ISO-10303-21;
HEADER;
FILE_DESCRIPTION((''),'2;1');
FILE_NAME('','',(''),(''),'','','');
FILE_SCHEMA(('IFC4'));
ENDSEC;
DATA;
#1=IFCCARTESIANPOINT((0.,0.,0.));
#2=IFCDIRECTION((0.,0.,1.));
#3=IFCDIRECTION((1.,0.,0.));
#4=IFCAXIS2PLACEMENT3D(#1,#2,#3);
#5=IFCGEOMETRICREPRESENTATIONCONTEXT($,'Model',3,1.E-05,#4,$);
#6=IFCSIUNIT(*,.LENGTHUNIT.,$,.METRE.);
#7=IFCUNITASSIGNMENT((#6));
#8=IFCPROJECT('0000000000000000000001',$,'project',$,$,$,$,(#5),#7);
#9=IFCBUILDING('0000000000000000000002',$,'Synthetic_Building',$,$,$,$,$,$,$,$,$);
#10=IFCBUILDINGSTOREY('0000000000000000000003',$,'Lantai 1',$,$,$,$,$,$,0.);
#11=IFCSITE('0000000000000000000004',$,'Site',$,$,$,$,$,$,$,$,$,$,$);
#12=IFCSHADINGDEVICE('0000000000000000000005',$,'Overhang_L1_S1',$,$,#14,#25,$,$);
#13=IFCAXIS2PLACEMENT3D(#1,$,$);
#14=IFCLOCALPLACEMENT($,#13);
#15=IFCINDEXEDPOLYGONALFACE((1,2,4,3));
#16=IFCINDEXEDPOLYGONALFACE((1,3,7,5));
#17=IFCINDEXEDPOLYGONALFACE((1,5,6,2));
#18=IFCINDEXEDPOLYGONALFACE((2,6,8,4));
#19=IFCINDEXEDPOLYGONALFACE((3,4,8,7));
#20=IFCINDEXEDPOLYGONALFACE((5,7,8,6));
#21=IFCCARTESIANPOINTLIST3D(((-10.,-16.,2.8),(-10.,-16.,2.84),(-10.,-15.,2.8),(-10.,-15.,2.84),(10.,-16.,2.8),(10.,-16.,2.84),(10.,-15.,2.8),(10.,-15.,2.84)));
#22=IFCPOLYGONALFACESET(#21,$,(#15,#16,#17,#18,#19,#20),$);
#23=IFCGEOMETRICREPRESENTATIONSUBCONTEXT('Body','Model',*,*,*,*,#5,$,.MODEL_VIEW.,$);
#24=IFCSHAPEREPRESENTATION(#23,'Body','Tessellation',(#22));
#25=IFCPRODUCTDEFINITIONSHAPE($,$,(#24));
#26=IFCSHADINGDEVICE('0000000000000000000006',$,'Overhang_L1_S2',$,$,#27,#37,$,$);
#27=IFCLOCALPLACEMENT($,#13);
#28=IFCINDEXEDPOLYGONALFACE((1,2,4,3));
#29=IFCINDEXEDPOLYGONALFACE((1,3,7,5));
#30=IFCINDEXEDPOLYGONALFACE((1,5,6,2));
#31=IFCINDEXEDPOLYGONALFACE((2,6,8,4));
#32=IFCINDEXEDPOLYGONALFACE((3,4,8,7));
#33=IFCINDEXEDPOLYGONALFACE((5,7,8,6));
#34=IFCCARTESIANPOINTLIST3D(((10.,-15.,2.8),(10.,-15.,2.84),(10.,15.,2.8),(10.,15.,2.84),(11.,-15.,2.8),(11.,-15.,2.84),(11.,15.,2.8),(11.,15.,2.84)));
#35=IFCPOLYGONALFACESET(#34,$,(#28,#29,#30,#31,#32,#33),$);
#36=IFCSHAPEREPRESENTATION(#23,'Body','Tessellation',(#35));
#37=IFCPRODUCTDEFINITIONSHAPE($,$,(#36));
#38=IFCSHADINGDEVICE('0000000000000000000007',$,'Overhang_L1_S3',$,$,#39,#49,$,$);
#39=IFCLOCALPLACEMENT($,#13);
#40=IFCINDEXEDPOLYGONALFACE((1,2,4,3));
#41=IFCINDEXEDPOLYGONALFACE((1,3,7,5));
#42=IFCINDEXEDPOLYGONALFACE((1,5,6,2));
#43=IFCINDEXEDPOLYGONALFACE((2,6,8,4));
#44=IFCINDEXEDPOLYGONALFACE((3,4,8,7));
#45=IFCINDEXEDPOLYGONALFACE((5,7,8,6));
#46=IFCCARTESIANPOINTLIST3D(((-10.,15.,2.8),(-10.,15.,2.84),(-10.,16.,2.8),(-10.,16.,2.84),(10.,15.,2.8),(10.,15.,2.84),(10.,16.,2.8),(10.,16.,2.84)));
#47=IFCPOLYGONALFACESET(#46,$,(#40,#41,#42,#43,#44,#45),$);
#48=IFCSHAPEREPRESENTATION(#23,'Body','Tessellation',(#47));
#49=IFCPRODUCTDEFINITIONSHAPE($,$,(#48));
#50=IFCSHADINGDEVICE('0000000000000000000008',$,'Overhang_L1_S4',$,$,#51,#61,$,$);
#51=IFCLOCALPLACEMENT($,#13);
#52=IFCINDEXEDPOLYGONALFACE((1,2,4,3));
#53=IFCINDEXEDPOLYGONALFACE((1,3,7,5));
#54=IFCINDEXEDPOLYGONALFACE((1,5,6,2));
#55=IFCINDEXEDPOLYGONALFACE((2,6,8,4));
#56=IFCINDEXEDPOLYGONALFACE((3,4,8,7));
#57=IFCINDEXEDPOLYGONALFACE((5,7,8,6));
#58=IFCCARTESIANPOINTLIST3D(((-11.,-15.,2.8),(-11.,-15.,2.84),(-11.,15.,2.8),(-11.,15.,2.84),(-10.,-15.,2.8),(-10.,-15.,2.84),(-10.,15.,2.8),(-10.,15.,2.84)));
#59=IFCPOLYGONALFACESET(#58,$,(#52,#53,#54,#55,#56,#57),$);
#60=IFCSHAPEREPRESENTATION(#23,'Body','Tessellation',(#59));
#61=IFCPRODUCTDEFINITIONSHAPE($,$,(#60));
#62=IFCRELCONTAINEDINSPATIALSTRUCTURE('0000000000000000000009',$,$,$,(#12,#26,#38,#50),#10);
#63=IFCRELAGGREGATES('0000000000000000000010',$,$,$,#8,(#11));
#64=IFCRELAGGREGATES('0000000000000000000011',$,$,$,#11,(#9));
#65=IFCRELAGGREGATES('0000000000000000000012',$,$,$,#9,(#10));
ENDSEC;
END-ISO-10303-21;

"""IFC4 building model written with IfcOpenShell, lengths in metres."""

from ifc_helpers import new_model, si_unit, frame, origin_with_axes, place, context, subcontext, project, spatial, polyline, outline, extrude, element, save


model = new_model("IFC4")

# Units and contexts
model_context = context("Model", 3, precision=1e-05, world=origin_with_axes())
body_context = subcontext(model_context, "Body", "Model", "MODEL_VIEW")
ifc_project = project(units=[si_unit("LENGTHUNIT", "METRE")], contexts=[model_context])

# Site, building, storey
site = spatial("IfcSite", under=ifc_project, Name="Site")
building = spatial("IfcBuilding", under=site, Name="Synthetic_Building")
storey = spatial("IfcBuildingStorey", under=building, Name="Lantai 1", Elevation=0.0)

# Shading devices
shading_device_1_placement = place(None, origin_with_axes())
element("IfcShadingDevice", 1, at=shading_device_1_placement, inside=storey, Name="Overhang_L1_S1", context=body_context, shape_type="SweptSolid", body=[
    extrude(outline(polyline([(-10.0, -15.0), (-10.0, -16.0), (10.0, -16.0), (10.0, -15.0), (-10.0, -15.0)])), frame((0.0, 0.0, 2.8), z_axis=(0.0, 0.0, 1.0), x_axis=(1.0, 0.0, 0.0)), (0.0, 0.0, 1.0), 0.04),
])
shading_device_2_placement = place(None, origin_with_axes())
element("IfcShadingDevice", 2, at=shading_device_2_placement, inside=storey, Name="Overhang_L1_S2", context=body_context, shape_type="SweptSolid", body=[
    extrude(outline(polyline([(10.0, -15.0), (11.0, -15.0), (11.0, 15.0), (10.0, 15.0), (10.0, -15.0)])), frame((0.0, 0.0, 2.8), z_axis=(0.0, 0.0, 1.0), x_axis=(1.0, 0.0, 0.0)), (0.0, 0.0, 1.0), 0.04),
])
shading_device_3_placement = place(None, origin_with_axes())
element("IfcShadingDevice", 3, at=shading_device_3_placement, inside=storey, Name="Overhang_L1_S3", context=body_context, shape_type="SweptSolid", body=[
    extrude(outline(polyline([(10.0, 15.0), (10.0, 16.0), (-10.0, 16.0), (-10.0, 15.0), (10.0, 15.0)])), frame((0.0, 0.0, 2.8), z_axis=(0.0, 0.0, 1.0), x_axis=(1.0, 0.0, 0.0)), (0.0, 0.0, 1.0), 0.04),
])
shading_device_4_placement = place(None, origin_with_axes())
element("IfcShadingDevice", 4, at=shading_device_4_placement, inside=storey, Name="Overhang_L1_S4", context=body_context, shape_type="SweptSolid", body=[
    extrude(outline(polyline([(-10.0, 15.0), (-11.0, 15.0), (-11.0, -15.0), (-10.0, -15.0), (-10.0, 15.0)])), frame((0.0, 0.0, 2.8), z_axis=(0.0, 0.0, 1.0), x_axis=(1.0, 0.0, 0.0)), (0.0, 0.0, 1.0), 0.04),
])

save(model, "model.ifc")
